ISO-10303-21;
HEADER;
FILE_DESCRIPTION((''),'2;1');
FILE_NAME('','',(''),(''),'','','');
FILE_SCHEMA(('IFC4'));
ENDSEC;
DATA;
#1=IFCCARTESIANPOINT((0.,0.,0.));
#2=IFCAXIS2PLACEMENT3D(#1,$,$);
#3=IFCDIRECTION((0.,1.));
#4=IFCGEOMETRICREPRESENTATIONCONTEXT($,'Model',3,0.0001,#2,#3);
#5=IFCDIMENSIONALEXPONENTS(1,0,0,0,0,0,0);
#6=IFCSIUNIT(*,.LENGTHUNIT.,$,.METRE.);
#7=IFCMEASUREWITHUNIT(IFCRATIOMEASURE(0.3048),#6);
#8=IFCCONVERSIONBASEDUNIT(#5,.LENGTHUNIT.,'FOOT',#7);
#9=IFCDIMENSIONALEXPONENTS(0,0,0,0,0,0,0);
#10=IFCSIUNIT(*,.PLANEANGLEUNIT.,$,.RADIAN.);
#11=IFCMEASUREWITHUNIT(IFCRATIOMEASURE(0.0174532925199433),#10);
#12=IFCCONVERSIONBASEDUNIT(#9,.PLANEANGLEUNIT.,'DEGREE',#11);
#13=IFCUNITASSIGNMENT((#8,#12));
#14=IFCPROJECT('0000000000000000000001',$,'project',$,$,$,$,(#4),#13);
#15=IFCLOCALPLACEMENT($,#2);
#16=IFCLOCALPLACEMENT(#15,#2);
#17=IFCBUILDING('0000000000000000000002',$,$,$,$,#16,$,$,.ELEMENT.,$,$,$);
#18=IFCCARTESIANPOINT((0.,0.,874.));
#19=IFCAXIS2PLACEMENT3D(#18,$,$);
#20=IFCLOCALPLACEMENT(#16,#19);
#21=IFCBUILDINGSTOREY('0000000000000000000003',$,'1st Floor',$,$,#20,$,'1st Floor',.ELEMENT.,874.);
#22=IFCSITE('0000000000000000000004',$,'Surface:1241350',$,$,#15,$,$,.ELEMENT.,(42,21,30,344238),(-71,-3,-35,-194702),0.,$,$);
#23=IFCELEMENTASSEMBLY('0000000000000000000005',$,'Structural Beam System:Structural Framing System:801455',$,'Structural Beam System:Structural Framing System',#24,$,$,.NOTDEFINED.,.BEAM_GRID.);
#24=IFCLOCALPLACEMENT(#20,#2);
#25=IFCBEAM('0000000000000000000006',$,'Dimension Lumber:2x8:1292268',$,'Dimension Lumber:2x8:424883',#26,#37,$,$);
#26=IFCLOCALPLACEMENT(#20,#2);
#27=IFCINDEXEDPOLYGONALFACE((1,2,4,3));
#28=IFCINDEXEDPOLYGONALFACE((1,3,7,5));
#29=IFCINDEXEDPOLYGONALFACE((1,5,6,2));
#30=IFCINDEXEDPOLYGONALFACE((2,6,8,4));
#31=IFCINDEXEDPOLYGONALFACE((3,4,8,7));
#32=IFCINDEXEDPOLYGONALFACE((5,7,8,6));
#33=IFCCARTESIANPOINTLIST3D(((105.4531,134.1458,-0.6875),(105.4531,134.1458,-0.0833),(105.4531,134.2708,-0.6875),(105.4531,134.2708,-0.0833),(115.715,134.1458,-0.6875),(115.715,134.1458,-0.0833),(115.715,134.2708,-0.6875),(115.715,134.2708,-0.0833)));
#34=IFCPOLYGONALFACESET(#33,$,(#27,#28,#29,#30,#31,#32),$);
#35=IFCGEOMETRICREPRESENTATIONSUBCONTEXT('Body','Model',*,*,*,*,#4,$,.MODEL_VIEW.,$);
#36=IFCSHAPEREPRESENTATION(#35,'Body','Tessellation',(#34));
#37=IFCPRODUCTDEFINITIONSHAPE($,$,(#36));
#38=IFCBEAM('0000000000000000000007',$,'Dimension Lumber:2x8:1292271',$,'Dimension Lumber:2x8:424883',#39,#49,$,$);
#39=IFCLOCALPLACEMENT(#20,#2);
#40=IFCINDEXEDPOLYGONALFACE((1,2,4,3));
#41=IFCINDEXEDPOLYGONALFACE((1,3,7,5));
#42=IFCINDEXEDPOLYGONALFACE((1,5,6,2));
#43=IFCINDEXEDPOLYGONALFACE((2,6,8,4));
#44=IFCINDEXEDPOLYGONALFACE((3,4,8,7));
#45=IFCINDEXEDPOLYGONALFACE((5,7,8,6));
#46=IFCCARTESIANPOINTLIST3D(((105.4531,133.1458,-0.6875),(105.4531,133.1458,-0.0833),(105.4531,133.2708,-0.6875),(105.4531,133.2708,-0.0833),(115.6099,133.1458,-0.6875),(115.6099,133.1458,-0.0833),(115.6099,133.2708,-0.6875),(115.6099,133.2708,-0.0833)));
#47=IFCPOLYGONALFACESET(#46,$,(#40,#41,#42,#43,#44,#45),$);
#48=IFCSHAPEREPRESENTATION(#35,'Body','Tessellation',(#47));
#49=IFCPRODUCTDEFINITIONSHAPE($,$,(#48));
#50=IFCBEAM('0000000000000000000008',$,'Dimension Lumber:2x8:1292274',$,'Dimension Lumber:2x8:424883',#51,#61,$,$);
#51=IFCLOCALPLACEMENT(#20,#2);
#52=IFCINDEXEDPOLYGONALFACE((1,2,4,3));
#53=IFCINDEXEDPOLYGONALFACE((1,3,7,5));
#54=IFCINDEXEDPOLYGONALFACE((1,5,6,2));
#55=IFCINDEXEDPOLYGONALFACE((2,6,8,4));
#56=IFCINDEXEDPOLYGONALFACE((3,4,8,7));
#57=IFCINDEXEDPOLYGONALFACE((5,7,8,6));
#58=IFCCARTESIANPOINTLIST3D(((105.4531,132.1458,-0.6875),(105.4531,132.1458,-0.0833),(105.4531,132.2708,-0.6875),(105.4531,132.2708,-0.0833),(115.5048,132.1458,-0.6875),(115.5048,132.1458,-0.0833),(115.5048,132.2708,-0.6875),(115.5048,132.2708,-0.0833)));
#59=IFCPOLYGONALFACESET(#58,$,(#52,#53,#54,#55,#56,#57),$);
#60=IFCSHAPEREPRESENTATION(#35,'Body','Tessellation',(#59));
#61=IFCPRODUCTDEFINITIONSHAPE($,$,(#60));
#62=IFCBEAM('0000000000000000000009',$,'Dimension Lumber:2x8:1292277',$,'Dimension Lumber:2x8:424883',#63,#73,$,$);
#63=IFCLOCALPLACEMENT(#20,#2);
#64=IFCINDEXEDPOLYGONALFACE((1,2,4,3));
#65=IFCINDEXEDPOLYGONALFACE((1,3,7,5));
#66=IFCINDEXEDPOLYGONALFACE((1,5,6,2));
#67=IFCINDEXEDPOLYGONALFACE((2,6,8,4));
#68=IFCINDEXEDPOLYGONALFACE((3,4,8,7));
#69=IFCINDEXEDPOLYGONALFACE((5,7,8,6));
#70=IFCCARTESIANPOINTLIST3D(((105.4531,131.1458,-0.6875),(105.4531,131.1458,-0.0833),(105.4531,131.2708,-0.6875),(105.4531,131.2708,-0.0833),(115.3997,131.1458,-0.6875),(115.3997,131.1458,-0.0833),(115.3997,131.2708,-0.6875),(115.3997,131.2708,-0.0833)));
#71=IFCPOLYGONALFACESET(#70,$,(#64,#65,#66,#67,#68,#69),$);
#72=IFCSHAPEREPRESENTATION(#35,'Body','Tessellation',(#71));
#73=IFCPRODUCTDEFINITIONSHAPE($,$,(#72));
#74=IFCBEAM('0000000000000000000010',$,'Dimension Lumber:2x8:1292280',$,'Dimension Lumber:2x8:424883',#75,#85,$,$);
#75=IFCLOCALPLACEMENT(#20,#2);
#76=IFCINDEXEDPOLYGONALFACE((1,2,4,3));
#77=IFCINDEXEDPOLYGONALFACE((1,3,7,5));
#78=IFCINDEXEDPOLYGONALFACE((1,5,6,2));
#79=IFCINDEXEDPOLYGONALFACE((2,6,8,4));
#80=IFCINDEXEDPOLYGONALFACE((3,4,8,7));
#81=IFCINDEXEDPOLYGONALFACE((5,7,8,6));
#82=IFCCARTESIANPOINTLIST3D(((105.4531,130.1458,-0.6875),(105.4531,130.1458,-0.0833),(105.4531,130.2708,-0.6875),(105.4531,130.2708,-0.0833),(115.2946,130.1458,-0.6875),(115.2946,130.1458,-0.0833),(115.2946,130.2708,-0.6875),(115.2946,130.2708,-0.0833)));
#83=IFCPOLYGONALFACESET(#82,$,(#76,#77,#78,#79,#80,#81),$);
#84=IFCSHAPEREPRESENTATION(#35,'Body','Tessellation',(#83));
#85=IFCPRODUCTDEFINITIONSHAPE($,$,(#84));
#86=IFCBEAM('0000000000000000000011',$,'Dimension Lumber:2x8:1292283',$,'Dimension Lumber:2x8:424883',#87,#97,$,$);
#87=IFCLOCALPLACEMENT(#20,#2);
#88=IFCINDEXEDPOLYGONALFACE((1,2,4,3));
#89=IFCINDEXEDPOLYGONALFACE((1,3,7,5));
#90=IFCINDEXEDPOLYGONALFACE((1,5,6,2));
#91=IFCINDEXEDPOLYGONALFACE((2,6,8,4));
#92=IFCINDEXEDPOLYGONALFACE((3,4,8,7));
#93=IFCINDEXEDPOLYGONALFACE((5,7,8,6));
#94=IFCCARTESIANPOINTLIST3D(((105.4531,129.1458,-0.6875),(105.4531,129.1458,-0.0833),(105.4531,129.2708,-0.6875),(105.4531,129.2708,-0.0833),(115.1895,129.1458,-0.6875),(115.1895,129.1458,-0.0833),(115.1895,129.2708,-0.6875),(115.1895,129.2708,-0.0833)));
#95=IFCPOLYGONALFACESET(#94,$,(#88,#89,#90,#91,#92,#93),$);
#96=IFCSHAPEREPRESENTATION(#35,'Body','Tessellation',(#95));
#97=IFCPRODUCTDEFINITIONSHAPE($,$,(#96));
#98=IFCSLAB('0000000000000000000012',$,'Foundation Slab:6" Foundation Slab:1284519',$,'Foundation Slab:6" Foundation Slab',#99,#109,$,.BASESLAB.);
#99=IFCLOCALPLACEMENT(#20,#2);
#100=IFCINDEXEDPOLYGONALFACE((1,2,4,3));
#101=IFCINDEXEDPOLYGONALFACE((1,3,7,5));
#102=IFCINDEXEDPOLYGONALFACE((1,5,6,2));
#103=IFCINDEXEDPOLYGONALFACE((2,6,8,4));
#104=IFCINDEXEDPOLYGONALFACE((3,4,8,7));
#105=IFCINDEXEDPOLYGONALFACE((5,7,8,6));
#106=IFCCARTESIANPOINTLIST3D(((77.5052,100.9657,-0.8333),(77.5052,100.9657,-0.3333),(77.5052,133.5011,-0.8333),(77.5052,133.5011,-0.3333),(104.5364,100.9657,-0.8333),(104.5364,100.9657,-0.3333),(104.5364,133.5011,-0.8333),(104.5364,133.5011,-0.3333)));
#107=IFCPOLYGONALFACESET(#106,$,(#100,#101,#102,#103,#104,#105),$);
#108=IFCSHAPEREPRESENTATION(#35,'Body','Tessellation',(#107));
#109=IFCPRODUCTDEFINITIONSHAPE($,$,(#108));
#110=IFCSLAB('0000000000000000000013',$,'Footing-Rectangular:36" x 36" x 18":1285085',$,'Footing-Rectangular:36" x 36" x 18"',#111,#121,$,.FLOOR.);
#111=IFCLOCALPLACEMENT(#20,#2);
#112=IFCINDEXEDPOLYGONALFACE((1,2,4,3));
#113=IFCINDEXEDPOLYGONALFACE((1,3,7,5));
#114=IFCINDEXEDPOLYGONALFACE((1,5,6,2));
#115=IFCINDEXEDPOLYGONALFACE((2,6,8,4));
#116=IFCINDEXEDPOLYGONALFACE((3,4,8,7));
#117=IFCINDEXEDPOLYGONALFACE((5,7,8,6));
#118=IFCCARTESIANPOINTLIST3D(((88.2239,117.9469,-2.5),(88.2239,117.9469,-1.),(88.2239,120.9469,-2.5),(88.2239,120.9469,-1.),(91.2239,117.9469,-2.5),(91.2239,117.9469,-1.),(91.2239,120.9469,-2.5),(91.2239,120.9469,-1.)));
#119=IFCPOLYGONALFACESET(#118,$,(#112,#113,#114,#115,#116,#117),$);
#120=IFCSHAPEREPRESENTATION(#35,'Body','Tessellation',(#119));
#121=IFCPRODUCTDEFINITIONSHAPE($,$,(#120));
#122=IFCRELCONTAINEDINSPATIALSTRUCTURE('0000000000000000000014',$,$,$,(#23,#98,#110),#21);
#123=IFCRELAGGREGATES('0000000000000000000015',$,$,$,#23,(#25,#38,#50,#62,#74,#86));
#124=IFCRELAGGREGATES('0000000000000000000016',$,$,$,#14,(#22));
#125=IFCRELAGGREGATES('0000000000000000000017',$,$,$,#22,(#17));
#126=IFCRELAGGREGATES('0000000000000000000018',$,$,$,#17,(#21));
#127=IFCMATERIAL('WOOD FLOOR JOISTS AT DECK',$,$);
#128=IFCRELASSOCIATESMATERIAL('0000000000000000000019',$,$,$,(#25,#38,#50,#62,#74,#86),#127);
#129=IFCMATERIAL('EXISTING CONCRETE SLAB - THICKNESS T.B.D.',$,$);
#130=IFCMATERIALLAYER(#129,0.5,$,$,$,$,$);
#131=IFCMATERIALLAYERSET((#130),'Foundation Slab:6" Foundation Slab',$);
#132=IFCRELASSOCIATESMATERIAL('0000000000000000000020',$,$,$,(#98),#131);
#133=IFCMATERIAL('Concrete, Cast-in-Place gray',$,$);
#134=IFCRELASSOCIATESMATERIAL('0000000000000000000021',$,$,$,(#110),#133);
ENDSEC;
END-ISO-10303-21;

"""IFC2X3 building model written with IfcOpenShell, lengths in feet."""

from ifc_helpers import new_model, entity, si_unit, converted_unit, direction, frame, frame_2d, origin, origin_2d_with_axis, place, context, subcontext, project, spatial, rectangle, extrude, material, layer, layer_set, layer_usage, element, aggregate, save


model = new_model("IFC2X3")

# Units and contexts
model_context = context("Model", 3, precision=0.0001, world=origin(), true_north=direction((0.0, 1.0)))
body_context = subcontext(model_context, "Body", "Model", "MODEL_VIEW")
ifc_project = project(units=[converted_unit("LENGTHUNIT", "FOOT", entity("IfcRatioMeasure", 0.3048), si_unit("LENGTHUNIT", "METRE"), dimensions=[1, 0, 0, 0, 0, 0, 0]), converted_unit("PLANEANGLEUNIT", "DEGREE", entity("IfcRatioMeasure", 0.0174532925199433), si_unit("PLANEANGLEUNIT", "RADIAN"), dimensions=[0, 0, 0, 0, 0, 0, 0])], contexts=[model_context])

# Site, building, storey
site_placement = place(None, origin())
site = spatial("IfcSite", under=ifc_project, at=site_placement, Name="Surface:1241350", CompositionType="ELEMENT", RefLatitude=(42, 21, 30, 344238), RefLongitude=(-71, -3, -35, -194702), RefElevation=0.0)
building_placement = place(site_placement, origin())
building = spatial("IfcBuilding", under=site, at=building_placement, CompositionType="ELEMENT")
storey_placement = place(building_placement, frame((0.0, 0.0, 874.0)))
storey = spatial("IfcBuildingStorey", under=building, at=storey_placement, Name="1st Floor", LongName="1st Floor", CompositionType="ELEMENT", Elevation=874.0)

# Element assembly, beams
assembly_1_placement = place(storey_placement, origin())
assembly_1 = element("IfcElementAssembly", 1, at=assembly_1_placement, inside=storey, Name="Structural Beam System:Structural Framing System:801455", ObjectType="Structural Beam System:Structural Framing System", AssemblyPlace="NOTDEFINED", PredefinedType="BEAM_GRID")
ifc_material_1 = material(Name="WOOD FLOOR JOISTS AT DECK")
beam_1_placement = place(assembly_1_placement, frame((105.3906, 134.2083, 0.0)))
beam_1 = element("IfcBeam", 2, at=beam_1_placement, material=ifc_material_1, Name="Dimension Lumber:2x8:1292268", ObjectType="Dimension Lumber:2x8:424883", context=body_context, shape_type="SweptSolid", body=[
    extrude(rectangle(XDim=0.6042, YDim=0.125, at=origin_2d_with_axis()), frame((0.0625, 0.0, -0.3854), z_axis=(1.0, 0.0, 0.0), x_axis=(0.0, 0.0, -1.0)), (0.0, 0.0, 1.0), 10.2619),
])
beam_2_placement = place(assembly_1_placement, frame((105.3906, 133.2083, 0.0)))
beam_2 = element("IfcBeam", 3, at=beam_2_placement, material=ifc_material_1, Name="Dimension Lumber:2x8:1292271", ObjectType="Dimension Lumber:2x8:424883", context=body_context, shape_type="SweptSolid", body=[
    extrude(rectangle(XDim=0.6042, YDim=0.125, at=origin_2d_with_axis()), frame((0.0625, 0.0, -0.3854), z_axis=(1.0, 0.0, 0.0), x_axis=(0.0, 0.0, -1.0)), (0.0, 0.0, 1.0), 10.1568),
])
beam_3_placement = place(assembly_1_placement, frame((105.3906, 132.2083, 0.0)))
beam_3 = element("IfcBeam", 4, at=beam_3_placement, material=ifc_material_1, Name="Dimension Lumber:2x8:1292274", ObjectType="Dimension Lumber:2x8:424883", context=body_context, shape_type="SweptSolid", body=[
    extrude(rectangle(XDim=0.6042, YDim=0.125, at=origin_2d_with_axis()), frame((0.0625, 0.0, -0.3854), z_axis=(1.0, 0.0, 0.0), x_axis=(0.0, 0.0, -1.0)), (0.0, 0.0, 1.0), 10.0517),
])
beam_4_placement = place(assembly_1_placement, frame((105.3906, 131.2083, 0.0)))
beam_4 = element("IfcBeam", 5, at=beam_4_placement, material=ifc_material_1, Name="Dimension Lumber:2x8:1292277", ObjectType="Dimension Lumber:2x8:424883", context=body_context, shape_type="SweptSolid", body=[
    extrude(rectangle(XDim=0.6042, YDim=0.125, at=origin_2d_with_axis()), frame((0.0625, 0.0, -0.3854), z_axis=(1.0, 0.0, 0.0), x_axis=(0.0, 0.0, -1.0)), (0.0, 0.0, 1.0), 9.9466),
])
beam_5_placement = place(assembly_1_placement, frame((105.3906, 130.2083, 0.0)))
beam_5 = element("IfcBeam", 6, at=beam_5_placement, material=ifc_material_1, Name="Dimension Lumber:2x8:1292280", ObjectType="Dimension Lumber:2x8:424883", context=body_context, shape_type="SweptSolid", body=[
    extrude(rectangle(XDim=0.6042, YDim=0.125, at=origin_2d_with_axis()), frame((0.0625, 0.0, -0.3854), z_axis=(1.0, 0.0, 0.0), x_axis=(0.0, 0.0, -1.0)), (0.0, 0.0, 1.0), 9.8415),
])
beam_6_placement = place(assembly_1_placement, frame((105.3906, 129.2083, 0.0)))
beam_6 = element("IfcBeam", 7, at=beam_6_placement, material=ifc_material_1, Name="Dimension Lumber:2x8:1292283", ObjectType="Dimension Lumber:2x8:424883", context=body_context, shape_type="SweptSolid", body=[
    extrude(rectangle(XDim=0.6042, YDim=0.125, at=origin_2d_with_axis()), frame((0.0625, 0.0, -0.3854), z_axis=(1.0, 0.0, 0.0), x_axis=(0.0, 0.0, -1.0)), (0.0, 0.0, 1.0), 9.7364),
])
aggregate(assembly_1, [beam_1, beam_2, beam_3, beam_4, beam_5, beam_6])

# Slabs
ifc_material_2 = material(Name="EXISTING CONCRETE SLAB - THICKNESS T.B.D.")
ifc_layer = layer(ifc_material_2, 0.5)
ifc_layer_set = layer_set([ifc_layer], Name="Foundation Slab:6\" Foundation Slab")
ifc_layer_usage = layer_usage(ifc_layer_set, "AXIS3", "POSITIVE", 0.0)
slab_1_placement = place(storey_placement, origin())
element("IfcSlab", 8, at=slab_1_placement, inside=storey, material=ifc_layer_usage, Name="Foundation Slab:6\" Foundation Slab:1284519", ObjectType="Foundation Slab:6\" Foundation Slab", PredefinedType="BASESLAB", context=body_context, shape_type="SweptSolid", body=[
    extrude(rectangle(XDim=32.5354, YDim=27.0312, at=frame_2d((0.0, 0.0), x_axis=(1.0, 0.0))), frame((91.0208, 117.2334, -0.3333), z_axis=(0.0, 0.0, -1.0), x_axis=(0.0, 1.0, 0.0)), (0.0, 0.0, 1.0), 0.5),
])
ifc_material_3 = material(Name="Concrete, Cast-in-Place gray")
slab_2_placement = place(storey_placement, origin())
element("IfcSlab", 9, at=slab_2_placement, inside=storey, material=ifc_material_3, Name="Footing-Rectangular:36\" x 36\" x 18\":1285085", ObjectType="Footing-Rectangular:36\" x 36\" x 18\"", PredefinedType="FLOOR", context=body_context, shape_type="SweptSolid", body=[
    extrude(rectangle(XDim=3.0, YDim=3.0, at=origin_2d_with_axis()), frame((89.7239, 119.4469, -2.5), z_axis=(0.0, 0.0, 1.0), x_axis=(0.0, -1.0, 0.0)), (0.0, 0.0, 1.0), 1.5),
])

save(model, "model.ifc")
